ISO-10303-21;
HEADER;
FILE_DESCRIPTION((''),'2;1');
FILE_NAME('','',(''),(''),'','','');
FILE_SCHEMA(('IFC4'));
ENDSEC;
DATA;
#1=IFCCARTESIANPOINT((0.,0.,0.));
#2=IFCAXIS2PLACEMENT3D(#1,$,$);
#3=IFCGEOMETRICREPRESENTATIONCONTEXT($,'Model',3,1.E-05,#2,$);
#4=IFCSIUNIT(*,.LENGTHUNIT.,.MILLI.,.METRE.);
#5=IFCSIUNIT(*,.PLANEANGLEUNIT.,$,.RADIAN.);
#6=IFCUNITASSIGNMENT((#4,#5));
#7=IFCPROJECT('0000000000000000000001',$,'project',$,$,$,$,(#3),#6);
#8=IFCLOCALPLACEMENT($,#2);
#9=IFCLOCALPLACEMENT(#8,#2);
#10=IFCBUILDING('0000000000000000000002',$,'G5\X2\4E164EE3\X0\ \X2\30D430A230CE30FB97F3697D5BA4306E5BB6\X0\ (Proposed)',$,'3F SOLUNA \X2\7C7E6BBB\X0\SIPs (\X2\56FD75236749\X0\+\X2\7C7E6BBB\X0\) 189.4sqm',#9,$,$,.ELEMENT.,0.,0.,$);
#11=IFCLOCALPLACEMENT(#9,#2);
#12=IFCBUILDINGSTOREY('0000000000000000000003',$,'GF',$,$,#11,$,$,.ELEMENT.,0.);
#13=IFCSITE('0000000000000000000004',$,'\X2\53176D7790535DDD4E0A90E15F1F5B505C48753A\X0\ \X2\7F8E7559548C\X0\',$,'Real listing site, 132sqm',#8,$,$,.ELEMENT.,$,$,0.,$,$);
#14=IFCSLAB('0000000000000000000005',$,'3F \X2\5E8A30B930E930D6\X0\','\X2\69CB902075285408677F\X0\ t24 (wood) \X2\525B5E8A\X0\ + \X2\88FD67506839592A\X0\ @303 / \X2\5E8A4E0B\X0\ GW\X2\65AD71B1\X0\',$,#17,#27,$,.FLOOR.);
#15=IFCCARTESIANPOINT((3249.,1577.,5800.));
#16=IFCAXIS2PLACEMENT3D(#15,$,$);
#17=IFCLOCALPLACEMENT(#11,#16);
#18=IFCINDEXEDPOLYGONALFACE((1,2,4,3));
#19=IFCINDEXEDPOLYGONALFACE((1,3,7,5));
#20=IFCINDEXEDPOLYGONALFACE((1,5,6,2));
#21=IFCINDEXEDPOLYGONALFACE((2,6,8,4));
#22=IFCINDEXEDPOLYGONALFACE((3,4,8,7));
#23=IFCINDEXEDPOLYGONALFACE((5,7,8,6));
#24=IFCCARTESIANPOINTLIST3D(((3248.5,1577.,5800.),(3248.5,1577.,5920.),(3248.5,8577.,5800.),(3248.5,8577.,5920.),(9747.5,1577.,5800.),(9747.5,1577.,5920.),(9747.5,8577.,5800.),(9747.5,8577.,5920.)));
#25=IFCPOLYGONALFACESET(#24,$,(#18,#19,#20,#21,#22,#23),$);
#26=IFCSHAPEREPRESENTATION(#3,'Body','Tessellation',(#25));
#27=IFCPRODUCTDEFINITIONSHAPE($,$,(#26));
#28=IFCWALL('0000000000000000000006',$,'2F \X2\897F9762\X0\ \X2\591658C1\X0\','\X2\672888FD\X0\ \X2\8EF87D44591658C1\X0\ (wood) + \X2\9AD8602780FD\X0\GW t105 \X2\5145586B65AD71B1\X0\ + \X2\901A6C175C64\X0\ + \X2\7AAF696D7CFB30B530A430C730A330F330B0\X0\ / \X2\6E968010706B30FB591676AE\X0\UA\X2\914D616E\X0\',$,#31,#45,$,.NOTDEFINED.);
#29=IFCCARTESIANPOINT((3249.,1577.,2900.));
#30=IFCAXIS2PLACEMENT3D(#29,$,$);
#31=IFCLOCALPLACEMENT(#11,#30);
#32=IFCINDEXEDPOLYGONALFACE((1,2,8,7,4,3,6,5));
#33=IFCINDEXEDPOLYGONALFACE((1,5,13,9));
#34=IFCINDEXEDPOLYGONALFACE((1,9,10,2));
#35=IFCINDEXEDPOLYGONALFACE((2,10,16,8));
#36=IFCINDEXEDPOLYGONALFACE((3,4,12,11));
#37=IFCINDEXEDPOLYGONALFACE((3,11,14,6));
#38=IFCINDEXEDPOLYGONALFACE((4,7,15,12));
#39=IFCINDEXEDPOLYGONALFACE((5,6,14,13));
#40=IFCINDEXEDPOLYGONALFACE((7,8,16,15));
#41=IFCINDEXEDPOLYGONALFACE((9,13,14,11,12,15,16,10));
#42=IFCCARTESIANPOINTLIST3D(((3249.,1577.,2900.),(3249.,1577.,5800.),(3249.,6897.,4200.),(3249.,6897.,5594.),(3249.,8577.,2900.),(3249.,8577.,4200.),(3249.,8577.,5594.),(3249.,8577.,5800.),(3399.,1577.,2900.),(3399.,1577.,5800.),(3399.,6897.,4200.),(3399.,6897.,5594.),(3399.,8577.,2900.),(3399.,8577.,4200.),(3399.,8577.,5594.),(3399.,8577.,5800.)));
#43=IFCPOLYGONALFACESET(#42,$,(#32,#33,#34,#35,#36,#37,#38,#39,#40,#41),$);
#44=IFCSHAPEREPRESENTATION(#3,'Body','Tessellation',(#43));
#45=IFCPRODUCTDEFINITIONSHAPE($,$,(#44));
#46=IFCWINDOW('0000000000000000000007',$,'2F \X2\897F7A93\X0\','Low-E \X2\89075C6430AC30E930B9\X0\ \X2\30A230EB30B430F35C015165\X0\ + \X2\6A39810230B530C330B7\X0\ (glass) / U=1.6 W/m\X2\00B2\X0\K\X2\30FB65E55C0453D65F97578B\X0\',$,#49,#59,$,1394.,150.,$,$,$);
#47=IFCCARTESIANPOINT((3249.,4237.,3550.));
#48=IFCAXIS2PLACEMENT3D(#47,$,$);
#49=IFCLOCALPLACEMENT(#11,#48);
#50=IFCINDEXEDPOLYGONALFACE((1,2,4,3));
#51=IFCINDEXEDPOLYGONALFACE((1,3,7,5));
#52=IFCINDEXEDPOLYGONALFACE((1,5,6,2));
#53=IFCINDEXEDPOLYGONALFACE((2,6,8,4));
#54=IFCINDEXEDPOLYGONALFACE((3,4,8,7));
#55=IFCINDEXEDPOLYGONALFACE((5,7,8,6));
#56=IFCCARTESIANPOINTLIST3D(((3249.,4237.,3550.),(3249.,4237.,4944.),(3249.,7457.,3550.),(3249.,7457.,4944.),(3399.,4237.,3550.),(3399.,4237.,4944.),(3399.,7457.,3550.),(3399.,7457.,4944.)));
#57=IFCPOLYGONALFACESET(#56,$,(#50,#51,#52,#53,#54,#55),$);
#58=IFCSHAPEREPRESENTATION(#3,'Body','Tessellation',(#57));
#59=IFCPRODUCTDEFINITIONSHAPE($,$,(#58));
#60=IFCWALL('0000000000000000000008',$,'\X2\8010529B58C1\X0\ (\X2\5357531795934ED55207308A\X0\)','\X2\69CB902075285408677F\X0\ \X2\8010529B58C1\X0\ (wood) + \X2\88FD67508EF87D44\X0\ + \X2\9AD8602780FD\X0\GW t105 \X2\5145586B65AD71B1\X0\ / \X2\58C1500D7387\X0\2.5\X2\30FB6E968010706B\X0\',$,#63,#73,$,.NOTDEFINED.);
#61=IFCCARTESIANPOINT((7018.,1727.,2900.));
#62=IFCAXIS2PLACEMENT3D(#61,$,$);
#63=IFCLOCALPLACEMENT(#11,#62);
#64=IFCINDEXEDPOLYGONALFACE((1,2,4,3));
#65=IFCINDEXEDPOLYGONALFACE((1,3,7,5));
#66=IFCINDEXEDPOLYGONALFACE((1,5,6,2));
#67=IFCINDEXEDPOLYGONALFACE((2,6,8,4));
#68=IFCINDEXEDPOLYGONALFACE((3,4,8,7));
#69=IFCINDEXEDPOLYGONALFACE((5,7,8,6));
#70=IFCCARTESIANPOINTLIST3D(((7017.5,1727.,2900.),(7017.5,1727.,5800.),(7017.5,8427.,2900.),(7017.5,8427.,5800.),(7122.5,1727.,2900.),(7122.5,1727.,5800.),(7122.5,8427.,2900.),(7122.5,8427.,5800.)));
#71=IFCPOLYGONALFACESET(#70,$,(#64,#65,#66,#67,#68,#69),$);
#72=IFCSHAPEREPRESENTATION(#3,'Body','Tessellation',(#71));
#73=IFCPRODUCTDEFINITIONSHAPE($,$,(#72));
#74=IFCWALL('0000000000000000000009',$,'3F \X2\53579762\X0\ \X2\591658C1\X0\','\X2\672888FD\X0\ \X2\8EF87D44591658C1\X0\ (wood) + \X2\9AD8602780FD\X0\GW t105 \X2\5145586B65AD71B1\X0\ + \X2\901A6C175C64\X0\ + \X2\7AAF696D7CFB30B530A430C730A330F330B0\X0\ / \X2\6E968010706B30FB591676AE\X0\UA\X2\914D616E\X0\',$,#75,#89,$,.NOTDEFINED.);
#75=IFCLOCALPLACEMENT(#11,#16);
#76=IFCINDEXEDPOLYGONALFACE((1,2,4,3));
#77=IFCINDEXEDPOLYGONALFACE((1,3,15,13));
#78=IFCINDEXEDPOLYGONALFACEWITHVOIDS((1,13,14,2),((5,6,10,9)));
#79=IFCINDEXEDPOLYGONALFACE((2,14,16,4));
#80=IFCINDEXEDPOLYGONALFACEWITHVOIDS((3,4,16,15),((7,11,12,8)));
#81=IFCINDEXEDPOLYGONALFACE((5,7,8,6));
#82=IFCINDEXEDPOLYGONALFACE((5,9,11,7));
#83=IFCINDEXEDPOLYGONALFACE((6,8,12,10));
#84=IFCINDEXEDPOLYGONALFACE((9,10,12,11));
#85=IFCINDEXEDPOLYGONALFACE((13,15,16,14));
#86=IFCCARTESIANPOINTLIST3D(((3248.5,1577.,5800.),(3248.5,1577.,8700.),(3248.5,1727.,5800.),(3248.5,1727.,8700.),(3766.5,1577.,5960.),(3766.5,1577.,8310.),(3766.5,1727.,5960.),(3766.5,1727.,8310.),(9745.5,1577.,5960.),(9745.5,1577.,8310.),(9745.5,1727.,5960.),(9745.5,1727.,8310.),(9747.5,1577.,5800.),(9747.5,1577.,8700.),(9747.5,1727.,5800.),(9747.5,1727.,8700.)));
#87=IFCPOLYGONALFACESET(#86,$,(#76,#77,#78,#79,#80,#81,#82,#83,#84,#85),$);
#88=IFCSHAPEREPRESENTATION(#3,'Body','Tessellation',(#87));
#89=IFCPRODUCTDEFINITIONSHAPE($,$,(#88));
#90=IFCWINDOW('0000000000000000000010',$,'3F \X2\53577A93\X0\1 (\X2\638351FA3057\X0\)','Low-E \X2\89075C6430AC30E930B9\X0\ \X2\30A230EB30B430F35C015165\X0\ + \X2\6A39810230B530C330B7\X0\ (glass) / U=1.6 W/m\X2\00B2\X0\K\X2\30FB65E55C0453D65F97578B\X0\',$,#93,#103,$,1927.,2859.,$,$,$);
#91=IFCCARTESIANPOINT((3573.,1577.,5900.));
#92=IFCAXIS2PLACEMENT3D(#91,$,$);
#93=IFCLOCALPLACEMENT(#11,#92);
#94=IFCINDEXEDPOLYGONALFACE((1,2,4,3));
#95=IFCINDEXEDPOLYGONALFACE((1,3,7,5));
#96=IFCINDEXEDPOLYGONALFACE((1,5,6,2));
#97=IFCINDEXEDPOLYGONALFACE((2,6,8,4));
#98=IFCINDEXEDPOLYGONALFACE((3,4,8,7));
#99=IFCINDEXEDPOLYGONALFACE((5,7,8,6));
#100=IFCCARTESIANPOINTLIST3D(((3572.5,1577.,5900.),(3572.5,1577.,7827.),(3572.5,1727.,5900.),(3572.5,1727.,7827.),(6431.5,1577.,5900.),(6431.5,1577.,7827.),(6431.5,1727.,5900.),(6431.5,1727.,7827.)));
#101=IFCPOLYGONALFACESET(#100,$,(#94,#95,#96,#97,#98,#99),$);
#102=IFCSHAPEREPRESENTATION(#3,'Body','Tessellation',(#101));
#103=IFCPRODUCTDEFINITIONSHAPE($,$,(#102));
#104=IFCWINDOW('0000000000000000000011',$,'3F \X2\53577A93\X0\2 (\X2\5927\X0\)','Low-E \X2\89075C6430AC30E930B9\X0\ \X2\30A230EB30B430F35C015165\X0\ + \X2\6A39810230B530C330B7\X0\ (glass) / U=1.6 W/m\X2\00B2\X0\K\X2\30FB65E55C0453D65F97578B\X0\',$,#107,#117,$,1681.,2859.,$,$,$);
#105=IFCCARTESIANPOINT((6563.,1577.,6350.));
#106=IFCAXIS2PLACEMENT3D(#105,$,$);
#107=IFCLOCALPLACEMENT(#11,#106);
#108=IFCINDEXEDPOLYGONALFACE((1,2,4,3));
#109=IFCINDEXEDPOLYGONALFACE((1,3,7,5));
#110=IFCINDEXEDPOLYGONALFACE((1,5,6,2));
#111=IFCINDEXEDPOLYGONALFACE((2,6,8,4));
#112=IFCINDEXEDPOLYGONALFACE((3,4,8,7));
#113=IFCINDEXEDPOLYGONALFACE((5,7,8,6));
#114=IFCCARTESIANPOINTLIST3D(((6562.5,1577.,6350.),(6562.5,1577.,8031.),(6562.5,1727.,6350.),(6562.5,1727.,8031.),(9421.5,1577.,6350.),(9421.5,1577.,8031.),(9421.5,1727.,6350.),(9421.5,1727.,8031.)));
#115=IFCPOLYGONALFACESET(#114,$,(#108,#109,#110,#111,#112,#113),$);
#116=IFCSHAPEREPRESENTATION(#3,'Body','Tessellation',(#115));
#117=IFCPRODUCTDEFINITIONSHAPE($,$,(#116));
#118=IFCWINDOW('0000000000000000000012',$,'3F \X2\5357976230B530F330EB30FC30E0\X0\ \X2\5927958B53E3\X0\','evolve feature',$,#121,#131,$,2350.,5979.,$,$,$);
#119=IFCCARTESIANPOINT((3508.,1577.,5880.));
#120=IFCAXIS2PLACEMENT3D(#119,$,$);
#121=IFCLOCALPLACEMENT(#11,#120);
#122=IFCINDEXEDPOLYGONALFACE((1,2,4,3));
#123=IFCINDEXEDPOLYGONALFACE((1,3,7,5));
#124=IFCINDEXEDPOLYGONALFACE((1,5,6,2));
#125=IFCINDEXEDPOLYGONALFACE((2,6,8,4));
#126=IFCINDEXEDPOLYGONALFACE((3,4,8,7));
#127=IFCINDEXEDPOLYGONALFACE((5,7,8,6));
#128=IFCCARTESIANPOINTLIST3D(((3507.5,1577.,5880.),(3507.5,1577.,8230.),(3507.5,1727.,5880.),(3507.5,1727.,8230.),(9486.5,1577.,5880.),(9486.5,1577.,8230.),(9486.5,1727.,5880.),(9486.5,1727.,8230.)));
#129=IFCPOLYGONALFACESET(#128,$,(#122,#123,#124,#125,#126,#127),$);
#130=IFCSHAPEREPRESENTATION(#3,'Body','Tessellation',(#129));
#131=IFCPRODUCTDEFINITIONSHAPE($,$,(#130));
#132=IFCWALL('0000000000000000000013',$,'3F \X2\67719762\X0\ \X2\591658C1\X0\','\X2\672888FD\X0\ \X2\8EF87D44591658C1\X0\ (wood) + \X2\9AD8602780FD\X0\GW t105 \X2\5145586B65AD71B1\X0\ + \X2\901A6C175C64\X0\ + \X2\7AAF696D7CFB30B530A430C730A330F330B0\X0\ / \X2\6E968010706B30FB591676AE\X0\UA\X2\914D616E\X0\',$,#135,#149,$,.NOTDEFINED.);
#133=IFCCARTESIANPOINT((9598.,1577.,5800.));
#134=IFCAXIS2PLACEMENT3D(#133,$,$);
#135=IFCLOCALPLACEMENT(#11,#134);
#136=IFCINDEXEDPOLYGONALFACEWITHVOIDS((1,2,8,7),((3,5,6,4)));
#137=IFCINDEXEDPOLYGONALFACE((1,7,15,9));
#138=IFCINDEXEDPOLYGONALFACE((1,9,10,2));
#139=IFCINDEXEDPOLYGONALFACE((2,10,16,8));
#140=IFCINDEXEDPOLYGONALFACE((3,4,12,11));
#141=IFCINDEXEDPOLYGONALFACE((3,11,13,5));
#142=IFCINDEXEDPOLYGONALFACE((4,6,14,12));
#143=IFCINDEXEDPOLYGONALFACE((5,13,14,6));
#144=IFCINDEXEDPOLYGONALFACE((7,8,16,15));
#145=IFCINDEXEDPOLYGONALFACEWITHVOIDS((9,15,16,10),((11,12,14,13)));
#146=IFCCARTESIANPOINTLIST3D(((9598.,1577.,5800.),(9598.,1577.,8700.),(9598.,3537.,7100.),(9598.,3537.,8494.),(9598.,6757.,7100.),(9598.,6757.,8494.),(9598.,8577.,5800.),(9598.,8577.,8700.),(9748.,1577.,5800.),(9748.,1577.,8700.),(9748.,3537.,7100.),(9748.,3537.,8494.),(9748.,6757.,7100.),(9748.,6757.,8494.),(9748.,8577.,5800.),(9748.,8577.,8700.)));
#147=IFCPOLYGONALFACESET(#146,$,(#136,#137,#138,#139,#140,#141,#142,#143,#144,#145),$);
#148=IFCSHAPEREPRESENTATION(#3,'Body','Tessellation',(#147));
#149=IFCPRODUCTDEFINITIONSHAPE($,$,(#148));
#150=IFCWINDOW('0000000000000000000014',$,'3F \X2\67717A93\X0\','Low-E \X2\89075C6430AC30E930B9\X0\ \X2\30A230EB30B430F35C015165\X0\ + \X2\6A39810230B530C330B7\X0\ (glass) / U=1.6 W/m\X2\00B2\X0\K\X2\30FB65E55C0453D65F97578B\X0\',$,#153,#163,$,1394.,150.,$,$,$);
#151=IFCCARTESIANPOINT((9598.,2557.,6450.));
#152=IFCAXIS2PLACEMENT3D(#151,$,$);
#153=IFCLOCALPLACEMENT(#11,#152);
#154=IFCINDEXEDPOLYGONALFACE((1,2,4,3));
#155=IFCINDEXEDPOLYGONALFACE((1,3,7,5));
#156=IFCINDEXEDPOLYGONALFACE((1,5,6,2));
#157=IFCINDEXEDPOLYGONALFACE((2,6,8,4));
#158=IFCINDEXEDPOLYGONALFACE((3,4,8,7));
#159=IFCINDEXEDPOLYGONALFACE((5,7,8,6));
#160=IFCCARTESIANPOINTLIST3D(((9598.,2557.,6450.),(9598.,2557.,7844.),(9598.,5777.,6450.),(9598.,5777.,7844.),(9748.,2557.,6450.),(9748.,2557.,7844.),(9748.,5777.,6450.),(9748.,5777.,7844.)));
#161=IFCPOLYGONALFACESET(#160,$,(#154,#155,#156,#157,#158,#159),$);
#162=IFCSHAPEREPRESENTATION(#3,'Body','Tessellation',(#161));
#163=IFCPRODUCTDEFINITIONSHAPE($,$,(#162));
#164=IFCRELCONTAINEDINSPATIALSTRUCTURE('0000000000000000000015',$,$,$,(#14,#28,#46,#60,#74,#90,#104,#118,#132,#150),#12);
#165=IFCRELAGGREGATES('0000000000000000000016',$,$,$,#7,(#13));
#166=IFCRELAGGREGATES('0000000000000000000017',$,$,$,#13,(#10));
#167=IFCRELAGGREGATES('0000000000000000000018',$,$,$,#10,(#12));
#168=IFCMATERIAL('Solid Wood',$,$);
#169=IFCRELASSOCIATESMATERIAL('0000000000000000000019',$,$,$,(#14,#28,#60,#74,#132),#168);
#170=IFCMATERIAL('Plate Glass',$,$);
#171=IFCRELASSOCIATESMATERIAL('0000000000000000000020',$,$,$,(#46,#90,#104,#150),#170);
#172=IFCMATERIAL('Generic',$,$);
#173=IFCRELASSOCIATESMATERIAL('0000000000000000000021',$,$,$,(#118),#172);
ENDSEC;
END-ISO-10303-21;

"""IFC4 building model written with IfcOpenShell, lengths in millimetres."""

from ifc_helpers import new_model, si_unit, frame, frame_2d, origin, place, context, project, spatial, rectangle, extrude, material, element, fill, save


model = new_model("IFC4")

# Units and contexts
model_context = context("Model", 3, precision=1e-05, world=origin())
ifc_project = project(units=[si_unit("LENGTHUNIT", "METRE", prefix="MILLI"), si_unit("PLANEANGLEUNIT", "RADIAN")], contexts=[model_context])

# Site, building, storey
site_placement = place(None, origin())
site = spatial("IfcSite", under=ifc_project, at=site_placement, Name="北海道川上郡弟子屈町 美留和", ObjectType="Real listing site, 132sqm", CompositionType="ELEMENT", RefElevation=0.0)
building_placement = place(site_placement, origin())
building = spatial("IfcBuilding", under=site, at=building_placement, Name="G5世代 ピアノ・音楽室の家 (Proposed)", ObjectType="3F SOLUNA 籾殻SIPs (国産杉+籾殻) 189.4sqm", CompositionType="ELEMENT", ElevationOfRefHeight=0.0, ElevationOfTerrain=0.0)
storey_placement = place(building_placement, origin())
storey = spatial("IfcBuildingStorey", under=building, at=storey_placement, Name="GF", CompositionType="ELEMENT", Elevation=0.0)

# Slab
ifc_material_1 = material(Name="Solid Wood")
slab_placement = place(storey_placement, frame((3249.0, 1577.0, 5800.0)))
element("IfcSlab", 1, at=slab_placement, inside=storey, material=ifc_material_1, Name="3F 床スラブ", Description="構造用合板 t24 (wood) 剛床 + 製材根太 @303 / 床下 GW断熱", PredefinedType="FLOOR", context=model_context, shape_type="SweptSolid", body=[
    extrude(rectangle(XDim=6499.0, YDim=7000.0, at=frame_2d((3249.0, 3500.0))), frame((3249.0, 1577.0, 5800.0)), (0.0, 0.0, 1.0), 120.0),
])

# Wall, opening, window
wall_1_placement = place(storey_placement, frame((3249.0, 1577.0, 2900.0)))
wall_1 = element("IfcWall", 2, at=wall_1_placement, inside=storey, material=ifc_material_1, Name="2F 西面 外壁", Description="木製 軸組外壁 (wood) + 高性能GW t105 充填断熱 + 通気層 + 窯業系サイディング / 準耐火・外皮UA配慮", PredefinedType="NOTDEFINED", context=model_context, shape_type="SweptSolid", body=[
    extrude(rectangle(XDim=150.0, YDim=7000.0, at=frame_2d((75.0, 3500.0))), frame((3249.0, 1577.0, 2900.0)), (0.0, 0.0, 1.0), 2900.0),
])
opening_1_placement = place(storey_placement, frame((3249.0, 4237.0, 3550.0)))
opening_1 = element("IfcOpeningElement", 3, at=opening_1_placement, cuts=wall_1, PredefinedType="NOTDEFINED", context=model_context, shape_type="SweptSolid", body=[
    extrude(rectangle(XDim=150.0, YDim=3220.0, at=frame_2d((75.0, 1610.0))), frame((3249.0, 4237.0, 3550.0)), (0.0, 0.0, 1.0), 1394.0),
])
ifc_material_2 = material(Name="Plate Glass")
window_1_placement = place(storey_placement, frame((3249.0, 4237.0, 3550.0)))
window_1 = element("IfcWindow", 4, at=window_1_placement, inside=storey, material=ifc_material_2, Name="2F 西窓", Description="Low-E 複層ガラス アルゴン封入 + 樹脂サッシ (glass) / U=1.6 W/m²K・日射取得型", OverallHeight=1394.0, OverallWidth=150.0, context=model_context, shape_type="SweptSolid", body=[
    extrude(rectangle(XDim=150.0, YDim=3220.0, at=frame_2d((75.0, 1610.0))), frame((3249.0, 4237.0, 3550.0)), (0.0, 0.0, 1.0), 1394.0),
])
fill(opening_1, window_1)

# Wall
wall_2_placement = place(storey_placement, frame((7018.0, 1727.0, 2900.0)))
element("IfcWall", 5, at=wall_2_placement, inside=storey, material=ifc_material_1, Name="耐力壁 (南北間仕切り)", Description="構造用合板 耐力壁 (wood) + 製材軸組 + 高性能GW t105 充填断熱 / 壁倍率2.5・準耐火", PredefinedType="NOTDEFINED", context=model_context, shape_type="SweptSolid", body=[
    extrude(rectangle(XDim=105.0, YDim=6700.0, at=frame_2d((52.0, 3350.0))), frame((7018.0, 1727.0, 2900.0)), (0.0, 0.0, 1.0), 2900.0),
])

# Wall, openings, windows
wall_3_placement = place(storey_placement, frame((3249.0, 1577.0, 5800.0)))
wall_3 = element("IfcWall", 6, at=wall_3_placement, inside=storey, material=ifc_material_1, Name="3F 南面 外壁", Description="木製 軸組外壁 (wood) + 高性能GW t105 充填断熱 + 通気層 + 窯業系サイディング / 準耐火・外皮UA配慮", PredefinedType="NOTDEFINED", context=model_context, shape_type="SweptSolid", body=[
    extrude(rectangle(XDim=6499.0, YDim=150.0, at=frame_2d((3249.0, 75.0))), frame((3249.0, 1577.0, 5800.0)), (0.0, 0.0, 1.0), 2900.0),
])
opening_2_placement = place(storey_placement, frame((3573.0, 1577.0, 5900.0)))
opening_2 = element("IfcOpeningElement", 7, at=opening_2_placement, cuts=wall_3, PredefinedType="NOTDEFINED", context=model_context, shape_type="SweptSolid", body=[
    extrude(rectangle(XDim=2859.0, YDim=150.0, at=frame_2d((1429.0, 75.0))), frame((3573.0, 1577.0, 5900.0)), (0.0, 0.0, 1.0), 1927.0),
])
opening_3_placement = place(storey_placement, frame((6563.0, 1577.0, 6350.0)))
opening_3 = element("IfcOpeningElement", 8, at=opening_3_placement, cuts=wall_3, PredefinedType="NOTDEFINED", context=model_context, shape_type="SweptSolid", body=[
    extrude(rectangle(XDim=2859.0, YDim=150.0, at=frame_2d((1429.0, 75.0))), frame((6563.0, 1577.0, 6350.0)), (0.0, 0.0, 1.0), 1681.0),
])
opening_4_placement = place(storey_placement, frame((3508.0, 1577.0, 5880.0)))
opening_4 = element("IfcOpeningElement", 9, at=opening_4_placement, cuts=wall_3, PredefinedType="NOTDEFINED", context=model_context, shape_type="SweptSolid", body=[
    extrude(rectangle(XDim=5979.0, YDim=150.0, at=frame_2d((2989.0, 75.0))), frame((3508.0, 1577.0, 5880.0)), (0.0, 0.0, 1.0), 2350.0),
])
window_2_placement = place(storey_placement, frame((3573.0, 1577.0, 5900.0)))
window_2 = element("IfcWindow", 10, at=window_2_placement, inside=storey, material=ifc_material_2, Name="3F 南窓1 (掃出し)", Description="Low-E 複層ガラス アルゴン封入 + 樹脂サッシ (glass) / U=1.6 W/m²K・日射取得型", OverallHeight=1927.0, OverallWidth=2859.0, context=model_context, shape_type="SweptSolid", body=[
    extrude(rectangle(XDim=2859.0, YDim=150.0, at=frame_2d((1429.0, 75.0))), frame((3573.0, 1577.0, 5900.0)), (0.0, 0.0, 1.0), 1927.0),
])
fill(opening_2, window_2)
window_3_placement = place(storey_placement, frame((6563.0, 1577.0, 6350.0)))
window_3 = element("IfcWindow", 11, at=window_3_placement, inside=storey, material=ifc_material_2, Name="3F 南窓2 (大)", Description="Low-E 複層ガラス アルゴン封入 + 樹脂サッシ (glass) / U=1.6 W/m²K・日射取得型", OverallHeight=1681.0, OverallWidth=2859.0, context=model_context, shape_type="SweptSolid", body=[
    extrude(rectangle(XDim=2859.0, YDim=150.0, at=frame_2d((1429.0, 75.0))), frame((6563.0, 1577.0, 6350.0)), (0.0, 0.0, 1.0), 1681.0),
])
fill(opening_3, window_3)
ifc_material_3 = material(Name="Generic")
window_4_placement = place(storey_placement, frame((3508.0, 1577.0, 5880.0)))
window_4 = element("IfcWindow", 12, at=window_4_placement, inside=storey, material=ifc_material_3, Name="3F 南面サンルーム 大開口", Description="evolve feature", OverallHeight=2350.0, OverallWidth=5979.0, context=model_context, shape_type="SweptSolid", body=[
    extrude(rectangle(XDim=5979.0, YDim=150.0, at=frame_2d((2989.0, 75.0))), frame((3508.0, 1577.0, 5880.0)), (0.0, 0.0, 1.0), 2350.0),
])
fill(opening_4, window_4)

# Wall, opening, window
wall_4_placement = place(storey_placement, frame((9598.0, 1577.0, 5800.0)))
wall_4 = element("IfcWall", 13, at=wall_4_placement, inside=storey, material=ifc_material_1, Name="3F 東面 外壁", Description="木製 軸組外壁 (wood) + 高性能GW t105 充填断熱 + 通気層 + 窯業系サイディング / 準耐火・外皮UA配慮", PredefinedType="NOTDEFINED", context=model_context, shape_type="SweptSolid", body=[
    extrude(rectangle(XDim=150.0, YDim=7000.0, at=frame_2d((75.0, 3500.0))), frame((9598.0, 1577.0, 5800.0)), (0.0, 0.0, 1.0), 2900.0),
])
opening_5_placement = place(storey_placement, frame((9598.0, 2557.0, 6450.0)))
opening_5 = element("IfcOpeningElement", 14, at=opening_5_placement, cuts=wall_4, PredefinedType="NOTDEFINED", context=model_context, shape_type="SweptSolid", body=[
    extrude(rectangle(XDim=150.0, YDim=3220.0, at=frame_2d((75.0, 1610.0))), frame((9598.0, 2557.0, 6450.0)), (0.0, 0.0, 1.0), 1394.0),
])
window_5_placement = place(storey_placement, frame((9598.0, 2557.0, 6450.0)))
window_5 = element("IfcWindow", 15, at=window_5_placement, inside=storey, material=ifc_material_2, Name="3F 東窓", Description="Low-E 複層ガラス アルゴン封入 + 樹脂サッシ (glass) / U=1.6 W/m²K・日射取得型", OverallHeight=1394.0, OverallWidth=150.0, context=model_context, shape_type="SweptSolid", body=[
    extrude(rectangle(XDim=150.0, YDim=3220.0, at=frame_2d((75.0, 1610.0))), frame((9598.0, 2557.0, 6450.0)), (0.0, 0.0, 1.0), 1394.0),
])
fill(opening_5, window_5)

save(model, "model.ifc")
